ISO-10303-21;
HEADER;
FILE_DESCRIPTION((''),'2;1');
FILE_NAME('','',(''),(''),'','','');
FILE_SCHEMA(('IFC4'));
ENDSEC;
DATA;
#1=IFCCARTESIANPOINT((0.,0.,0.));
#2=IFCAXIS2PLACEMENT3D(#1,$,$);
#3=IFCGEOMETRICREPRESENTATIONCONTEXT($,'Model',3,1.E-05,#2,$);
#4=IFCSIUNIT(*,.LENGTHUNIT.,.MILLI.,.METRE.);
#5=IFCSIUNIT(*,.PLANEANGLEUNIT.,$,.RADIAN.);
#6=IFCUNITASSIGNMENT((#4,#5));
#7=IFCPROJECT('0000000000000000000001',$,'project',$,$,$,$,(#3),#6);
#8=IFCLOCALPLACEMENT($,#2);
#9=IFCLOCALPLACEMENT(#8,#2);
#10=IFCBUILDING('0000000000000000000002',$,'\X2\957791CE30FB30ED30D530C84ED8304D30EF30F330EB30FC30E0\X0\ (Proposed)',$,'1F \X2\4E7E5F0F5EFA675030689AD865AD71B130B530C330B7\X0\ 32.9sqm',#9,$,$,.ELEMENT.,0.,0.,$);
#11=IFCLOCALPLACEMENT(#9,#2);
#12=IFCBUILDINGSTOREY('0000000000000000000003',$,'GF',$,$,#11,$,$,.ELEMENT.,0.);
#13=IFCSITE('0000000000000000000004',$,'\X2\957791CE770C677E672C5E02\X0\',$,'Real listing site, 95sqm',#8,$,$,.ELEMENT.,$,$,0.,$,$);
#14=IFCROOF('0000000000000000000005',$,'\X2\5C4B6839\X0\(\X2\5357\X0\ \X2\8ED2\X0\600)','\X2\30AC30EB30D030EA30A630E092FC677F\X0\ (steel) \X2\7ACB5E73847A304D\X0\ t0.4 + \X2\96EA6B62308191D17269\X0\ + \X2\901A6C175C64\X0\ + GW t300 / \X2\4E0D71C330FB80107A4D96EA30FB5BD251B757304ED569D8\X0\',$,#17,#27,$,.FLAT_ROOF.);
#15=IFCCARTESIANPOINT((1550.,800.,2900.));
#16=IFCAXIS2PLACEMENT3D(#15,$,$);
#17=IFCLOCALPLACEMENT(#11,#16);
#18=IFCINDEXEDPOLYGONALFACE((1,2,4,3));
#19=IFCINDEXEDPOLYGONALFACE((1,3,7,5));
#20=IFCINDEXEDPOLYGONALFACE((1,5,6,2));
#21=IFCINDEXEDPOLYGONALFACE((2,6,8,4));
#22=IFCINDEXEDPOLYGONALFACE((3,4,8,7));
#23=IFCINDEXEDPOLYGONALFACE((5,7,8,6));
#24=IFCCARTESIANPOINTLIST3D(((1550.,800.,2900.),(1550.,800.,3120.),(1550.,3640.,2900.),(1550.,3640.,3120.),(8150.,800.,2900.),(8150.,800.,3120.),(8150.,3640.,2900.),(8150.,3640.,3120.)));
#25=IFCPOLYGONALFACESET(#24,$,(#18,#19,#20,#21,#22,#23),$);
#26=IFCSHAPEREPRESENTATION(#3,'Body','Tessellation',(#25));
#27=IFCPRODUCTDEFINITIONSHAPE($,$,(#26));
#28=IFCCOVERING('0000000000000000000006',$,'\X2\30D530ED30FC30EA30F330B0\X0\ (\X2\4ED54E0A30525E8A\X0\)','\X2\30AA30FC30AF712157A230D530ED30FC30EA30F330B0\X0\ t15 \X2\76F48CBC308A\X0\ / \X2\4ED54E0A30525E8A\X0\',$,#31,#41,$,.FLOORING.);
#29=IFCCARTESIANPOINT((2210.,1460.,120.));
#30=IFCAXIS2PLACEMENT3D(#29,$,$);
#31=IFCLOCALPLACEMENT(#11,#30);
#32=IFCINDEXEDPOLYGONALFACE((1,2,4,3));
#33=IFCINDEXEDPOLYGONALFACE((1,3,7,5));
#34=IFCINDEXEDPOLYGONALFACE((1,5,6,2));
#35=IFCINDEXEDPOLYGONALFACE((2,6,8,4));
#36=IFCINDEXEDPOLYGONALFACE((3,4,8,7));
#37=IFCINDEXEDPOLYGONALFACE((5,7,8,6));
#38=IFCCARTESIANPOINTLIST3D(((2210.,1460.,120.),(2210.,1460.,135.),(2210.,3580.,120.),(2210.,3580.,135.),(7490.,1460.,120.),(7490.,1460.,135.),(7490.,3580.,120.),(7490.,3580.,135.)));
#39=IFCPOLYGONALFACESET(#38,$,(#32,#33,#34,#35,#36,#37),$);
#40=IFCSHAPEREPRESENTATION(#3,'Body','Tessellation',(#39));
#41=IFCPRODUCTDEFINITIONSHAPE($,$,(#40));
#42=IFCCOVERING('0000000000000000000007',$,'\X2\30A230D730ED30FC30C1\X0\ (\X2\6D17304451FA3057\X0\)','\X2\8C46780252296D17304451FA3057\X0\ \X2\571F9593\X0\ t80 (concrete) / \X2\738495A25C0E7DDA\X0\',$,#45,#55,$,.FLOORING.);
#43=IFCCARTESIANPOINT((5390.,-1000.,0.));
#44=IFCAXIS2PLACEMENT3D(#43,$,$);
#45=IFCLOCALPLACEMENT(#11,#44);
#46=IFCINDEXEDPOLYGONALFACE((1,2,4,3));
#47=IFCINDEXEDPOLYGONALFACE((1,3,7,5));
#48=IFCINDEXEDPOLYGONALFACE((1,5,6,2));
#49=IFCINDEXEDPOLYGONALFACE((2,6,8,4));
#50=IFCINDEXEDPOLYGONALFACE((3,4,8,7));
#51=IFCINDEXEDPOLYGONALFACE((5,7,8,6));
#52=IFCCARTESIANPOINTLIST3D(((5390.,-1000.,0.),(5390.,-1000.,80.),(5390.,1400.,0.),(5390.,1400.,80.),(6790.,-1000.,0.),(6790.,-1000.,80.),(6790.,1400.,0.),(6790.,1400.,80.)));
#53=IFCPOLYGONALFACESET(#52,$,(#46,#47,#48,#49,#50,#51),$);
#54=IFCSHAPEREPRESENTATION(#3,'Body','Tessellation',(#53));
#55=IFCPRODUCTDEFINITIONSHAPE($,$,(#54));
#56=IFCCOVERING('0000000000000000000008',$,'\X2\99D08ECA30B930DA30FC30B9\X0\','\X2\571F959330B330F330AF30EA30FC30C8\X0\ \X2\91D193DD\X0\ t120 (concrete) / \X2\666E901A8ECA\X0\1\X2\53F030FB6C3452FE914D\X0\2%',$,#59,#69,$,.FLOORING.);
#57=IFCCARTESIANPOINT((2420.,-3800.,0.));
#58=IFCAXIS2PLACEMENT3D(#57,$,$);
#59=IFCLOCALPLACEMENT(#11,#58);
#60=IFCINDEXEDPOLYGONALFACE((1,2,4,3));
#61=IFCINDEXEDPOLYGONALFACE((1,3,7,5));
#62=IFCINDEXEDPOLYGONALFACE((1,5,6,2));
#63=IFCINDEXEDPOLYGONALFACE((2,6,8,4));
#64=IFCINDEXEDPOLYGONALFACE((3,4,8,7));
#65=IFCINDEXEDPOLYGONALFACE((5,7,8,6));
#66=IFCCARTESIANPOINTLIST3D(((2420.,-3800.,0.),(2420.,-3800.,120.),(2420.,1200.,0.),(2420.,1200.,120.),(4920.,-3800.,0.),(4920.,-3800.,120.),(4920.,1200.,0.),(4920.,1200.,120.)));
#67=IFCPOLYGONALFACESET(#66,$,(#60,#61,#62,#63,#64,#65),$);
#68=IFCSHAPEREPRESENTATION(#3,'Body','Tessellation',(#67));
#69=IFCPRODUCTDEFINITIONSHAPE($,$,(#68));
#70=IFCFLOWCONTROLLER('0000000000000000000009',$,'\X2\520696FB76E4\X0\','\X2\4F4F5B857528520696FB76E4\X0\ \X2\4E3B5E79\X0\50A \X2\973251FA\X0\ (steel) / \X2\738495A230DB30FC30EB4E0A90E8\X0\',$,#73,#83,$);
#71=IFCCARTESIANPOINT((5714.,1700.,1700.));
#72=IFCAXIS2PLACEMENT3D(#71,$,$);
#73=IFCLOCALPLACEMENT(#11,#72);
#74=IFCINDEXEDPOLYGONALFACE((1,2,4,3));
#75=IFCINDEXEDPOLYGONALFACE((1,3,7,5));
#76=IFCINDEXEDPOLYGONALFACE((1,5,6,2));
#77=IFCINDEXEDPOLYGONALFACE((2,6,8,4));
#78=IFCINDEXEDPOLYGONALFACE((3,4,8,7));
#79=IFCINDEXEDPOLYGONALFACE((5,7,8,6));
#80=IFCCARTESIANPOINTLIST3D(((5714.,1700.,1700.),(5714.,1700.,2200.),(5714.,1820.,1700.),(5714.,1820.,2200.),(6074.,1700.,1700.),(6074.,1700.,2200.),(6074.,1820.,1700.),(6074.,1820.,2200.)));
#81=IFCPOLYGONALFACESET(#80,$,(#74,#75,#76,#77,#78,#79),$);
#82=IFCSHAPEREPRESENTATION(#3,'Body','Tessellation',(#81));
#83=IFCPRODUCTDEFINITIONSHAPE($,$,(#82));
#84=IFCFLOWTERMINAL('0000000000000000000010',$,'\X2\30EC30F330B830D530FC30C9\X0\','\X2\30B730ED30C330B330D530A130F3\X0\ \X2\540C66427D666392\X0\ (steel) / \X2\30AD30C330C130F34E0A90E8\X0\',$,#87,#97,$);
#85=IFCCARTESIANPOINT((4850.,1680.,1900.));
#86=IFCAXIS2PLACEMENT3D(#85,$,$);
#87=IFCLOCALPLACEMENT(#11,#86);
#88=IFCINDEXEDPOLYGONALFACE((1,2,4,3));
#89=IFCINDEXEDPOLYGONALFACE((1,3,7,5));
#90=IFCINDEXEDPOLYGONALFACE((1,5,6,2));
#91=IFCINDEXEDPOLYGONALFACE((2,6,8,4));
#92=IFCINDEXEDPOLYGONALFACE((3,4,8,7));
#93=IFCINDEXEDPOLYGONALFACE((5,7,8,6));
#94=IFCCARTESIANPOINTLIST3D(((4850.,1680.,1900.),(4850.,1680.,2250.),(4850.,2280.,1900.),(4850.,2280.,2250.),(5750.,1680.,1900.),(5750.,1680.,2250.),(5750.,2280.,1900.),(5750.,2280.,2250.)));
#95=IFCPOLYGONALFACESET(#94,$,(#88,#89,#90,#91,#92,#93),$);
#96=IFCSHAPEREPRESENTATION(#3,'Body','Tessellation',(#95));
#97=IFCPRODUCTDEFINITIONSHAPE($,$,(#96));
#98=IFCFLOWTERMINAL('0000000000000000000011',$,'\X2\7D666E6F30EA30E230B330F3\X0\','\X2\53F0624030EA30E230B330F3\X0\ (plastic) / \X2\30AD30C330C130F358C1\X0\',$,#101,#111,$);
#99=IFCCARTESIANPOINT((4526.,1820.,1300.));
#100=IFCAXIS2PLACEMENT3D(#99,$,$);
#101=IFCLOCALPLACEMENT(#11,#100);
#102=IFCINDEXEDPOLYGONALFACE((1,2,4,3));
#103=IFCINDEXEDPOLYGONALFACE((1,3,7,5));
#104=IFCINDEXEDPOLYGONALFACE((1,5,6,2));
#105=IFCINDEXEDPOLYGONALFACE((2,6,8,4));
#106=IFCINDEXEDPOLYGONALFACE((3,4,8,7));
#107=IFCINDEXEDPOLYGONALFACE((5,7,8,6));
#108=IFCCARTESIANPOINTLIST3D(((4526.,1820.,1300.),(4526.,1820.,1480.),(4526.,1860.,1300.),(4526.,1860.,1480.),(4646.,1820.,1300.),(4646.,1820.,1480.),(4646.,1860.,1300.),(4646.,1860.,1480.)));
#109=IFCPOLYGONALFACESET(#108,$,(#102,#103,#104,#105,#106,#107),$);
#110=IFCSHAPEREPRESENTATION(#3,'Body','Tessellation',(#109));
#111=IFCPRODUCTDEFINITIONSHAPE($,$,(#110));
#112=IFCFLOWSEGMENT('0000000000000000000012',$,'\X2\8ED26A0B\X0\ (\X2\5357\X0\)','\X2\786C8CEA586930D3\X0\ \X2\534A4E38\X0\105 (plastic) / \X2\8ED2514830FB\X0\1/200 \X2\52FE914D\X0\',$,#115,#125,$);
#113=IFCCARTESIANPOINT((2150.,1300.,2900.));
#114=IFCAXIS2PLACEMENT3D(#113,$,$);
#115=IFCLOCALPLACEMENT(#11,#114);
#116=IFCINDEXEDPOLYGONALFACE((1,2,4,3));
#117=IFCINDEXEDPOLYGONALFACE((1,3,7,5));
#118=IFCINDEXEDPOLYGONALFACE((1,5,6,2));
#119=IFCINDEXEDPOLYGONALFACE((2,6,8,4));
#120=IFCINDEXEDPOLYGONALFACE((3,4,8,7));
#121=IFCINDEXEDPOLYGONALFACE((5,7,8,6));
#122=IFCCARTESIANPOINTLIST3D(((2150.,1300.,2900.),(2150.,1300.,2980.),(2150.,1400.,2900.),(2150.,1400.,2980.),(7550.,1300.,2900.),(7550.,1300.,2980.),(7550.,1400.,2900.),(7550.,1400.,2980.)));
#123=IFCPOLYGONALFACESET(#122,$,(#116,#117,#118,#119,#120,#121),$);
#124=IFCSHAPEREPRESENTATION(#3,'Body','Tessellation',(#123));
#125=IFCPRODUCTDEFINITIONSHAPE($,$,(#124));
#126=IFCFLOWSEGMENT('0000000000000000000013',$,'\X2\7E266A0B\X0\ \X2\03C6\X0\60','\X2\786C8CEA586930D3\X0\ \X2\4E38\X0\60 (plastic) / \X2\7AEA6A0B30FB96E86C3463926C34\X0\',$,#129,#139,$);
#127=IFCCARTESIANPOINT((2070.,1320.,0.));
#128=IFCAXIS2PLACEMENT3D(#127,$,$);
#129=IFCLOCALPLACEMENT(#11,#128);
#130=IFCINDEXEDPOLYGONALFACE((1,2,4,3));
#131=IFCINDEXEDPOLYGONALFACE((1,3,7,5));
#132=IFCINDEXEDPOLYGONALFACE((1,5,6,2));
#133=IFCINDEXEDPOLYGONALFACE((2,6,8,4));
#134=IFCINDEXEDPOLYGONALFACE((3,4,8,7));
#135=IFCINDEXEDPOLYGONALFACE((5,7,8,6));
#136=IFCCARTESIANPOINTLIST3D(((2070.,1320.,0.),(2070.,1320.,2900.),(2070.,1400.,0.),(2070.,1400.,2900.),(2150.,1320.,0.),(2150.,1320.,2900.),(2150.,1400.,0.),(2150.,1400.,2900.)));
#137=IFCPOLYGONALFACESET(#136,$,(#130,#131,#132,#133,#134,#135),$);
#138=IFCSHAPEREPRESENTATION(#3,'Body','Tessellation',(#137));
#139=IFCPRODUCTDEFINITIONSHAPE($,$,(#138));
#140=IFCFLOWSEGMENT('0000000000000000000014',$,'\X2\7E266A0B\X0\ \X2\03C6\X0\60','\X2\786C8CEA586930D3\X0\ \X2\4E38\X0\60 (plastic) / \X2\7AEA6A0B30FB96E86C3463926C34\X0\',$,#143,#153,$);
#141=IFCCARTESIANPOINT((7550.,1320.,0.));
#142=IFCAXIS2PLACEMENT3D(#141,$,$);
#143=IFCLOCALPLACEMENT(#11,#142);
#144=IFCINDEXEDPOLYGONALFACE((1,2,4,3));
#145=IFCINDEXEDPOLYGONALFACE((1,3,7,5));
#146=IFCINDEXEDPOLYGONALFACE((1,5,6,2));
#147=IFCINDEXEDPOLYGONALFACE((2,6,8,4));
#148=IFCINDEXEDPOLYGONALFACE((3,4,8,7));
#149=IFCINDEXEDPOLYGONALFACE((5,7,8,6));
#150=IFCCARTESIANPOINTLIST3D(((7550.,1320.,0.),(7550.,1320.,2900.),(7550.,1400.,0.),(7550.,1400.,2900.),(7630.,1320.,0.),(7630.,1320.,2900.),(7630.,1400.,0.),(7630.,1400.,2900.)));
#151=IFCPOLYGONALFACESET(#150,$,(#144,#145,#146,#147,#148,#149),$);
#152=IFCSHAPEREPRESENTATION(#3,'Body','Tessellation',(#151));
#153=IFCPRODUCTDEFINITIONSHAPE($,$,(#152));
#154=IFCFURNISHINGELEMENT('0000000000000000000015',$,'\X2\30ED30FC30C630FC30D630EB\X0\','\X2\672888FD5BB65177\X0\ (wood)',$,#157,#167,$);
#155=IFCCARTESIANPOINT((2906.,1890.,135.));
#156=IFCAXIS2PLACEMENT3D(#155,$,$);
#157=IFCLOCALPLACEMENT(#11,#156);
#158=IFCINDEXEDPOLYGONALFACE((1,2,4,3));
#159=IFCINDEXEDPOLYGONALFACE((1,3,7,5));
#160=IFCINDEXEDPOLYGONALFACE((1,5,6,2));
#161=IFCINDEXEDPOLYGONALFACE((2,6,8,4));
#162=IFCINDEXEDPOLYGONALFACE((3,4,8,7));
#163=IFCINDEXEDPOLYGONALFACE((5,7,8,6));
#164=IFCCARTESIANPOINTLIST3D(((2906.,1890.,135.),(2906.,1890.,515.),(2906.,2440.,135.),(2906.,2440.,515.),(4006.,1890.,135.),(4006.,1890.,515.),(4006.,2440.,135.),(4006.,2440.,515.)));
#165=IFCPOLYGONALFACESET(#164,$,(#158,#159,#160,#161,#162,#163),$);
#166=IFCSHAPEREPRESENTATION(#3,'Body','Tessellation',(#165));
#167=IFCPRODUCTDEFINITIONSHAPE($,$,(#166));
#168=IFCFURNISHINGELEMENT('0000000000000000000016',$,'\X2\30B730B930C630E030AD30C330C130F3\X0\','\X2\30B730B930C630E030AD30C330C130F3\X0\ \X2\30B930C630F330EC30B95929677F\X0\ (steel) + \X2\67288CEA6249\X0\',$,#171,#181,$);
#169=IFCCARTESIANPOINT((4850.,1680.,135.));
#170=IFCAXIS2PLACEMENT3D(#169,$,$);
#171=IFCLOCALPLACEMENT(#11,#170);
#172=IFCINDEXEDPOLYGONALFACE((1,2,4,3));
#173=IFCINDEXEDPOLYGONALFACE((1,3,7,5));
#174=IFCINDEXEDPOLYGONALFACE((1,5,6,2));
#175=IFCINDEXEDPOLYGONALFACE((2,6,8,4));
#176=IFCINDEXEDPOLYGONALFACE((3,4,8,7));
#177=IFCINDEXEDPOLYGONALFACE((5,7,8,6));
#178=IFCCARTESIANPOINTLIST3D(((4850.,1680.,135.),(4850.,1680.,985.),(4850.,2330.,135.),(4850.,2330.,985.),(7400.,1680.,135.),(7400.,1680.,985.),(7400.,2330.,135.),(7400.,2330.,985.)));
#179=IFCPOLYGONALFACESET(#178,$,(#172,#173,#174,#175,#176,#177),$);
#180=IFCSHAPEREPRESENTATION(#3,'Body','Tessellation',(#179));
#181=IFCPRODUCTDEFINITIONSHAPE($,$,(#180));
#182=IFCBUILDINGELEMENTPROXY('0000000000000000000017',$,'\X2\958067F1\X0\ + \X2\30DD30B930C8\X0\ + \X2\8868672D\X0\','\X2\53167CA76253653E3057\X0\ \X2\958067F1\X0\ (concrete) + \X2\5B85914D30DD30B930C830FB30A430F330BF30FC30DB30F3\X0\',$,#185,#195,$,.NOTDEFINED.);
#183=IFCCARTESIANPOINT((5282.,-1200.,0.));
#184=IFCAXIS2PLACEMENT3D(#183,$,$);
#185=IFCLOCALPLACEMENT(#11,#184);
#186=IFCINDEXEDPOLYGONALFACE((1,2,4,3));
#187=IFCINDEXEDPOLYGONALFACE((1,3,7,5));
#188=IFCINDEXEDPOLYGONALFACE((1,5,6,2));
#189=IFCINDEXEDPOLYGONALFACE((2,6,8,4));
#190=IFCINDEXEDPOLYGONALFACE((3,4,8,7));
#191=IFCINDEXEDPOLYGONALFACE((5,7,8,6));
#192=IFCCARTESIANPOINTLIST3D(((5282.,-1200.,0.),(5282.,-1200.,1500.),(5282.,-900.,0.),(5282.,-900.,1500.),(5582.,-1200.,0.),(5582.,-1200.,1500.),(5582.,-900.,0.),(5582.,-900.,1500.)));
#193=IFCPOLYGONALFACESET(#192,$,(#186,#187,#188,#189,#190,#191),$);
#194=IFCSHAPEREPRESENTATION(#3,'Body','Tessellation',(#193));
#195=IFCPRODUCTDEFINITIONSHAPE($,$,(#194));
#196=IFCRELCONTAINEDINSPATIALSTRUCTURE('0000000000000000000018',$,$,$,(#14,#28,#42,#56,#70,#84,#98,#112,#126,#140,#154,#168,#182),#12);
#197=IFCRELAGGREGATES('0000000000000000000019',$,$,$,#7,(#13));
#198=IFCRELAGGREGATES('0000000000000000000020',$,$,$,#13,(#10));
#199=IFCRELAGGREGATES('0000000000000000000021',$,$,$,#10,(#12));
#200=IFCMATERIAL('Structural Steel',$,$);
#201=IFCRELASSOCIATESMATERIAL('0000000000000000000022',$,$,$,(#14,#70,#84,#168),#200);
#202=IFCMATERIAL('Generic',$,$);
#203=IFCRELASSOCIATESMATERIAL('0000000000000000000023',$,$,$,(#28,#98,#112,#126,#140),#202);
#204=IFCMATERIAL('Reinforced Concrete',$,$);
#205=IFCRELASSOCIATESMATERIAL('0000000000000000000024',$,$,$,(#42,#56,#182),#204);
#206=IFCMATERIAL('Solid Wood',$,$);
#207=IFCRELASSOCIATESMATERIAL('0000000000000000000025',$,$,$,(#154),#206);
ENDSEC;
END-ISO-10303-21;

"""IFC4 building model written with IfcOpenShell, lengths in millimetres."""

from ifc_helpers import new_model, si_unit, frame, frame_2d, origin, place, context, project, spatial, rectangle, extrude, material, element, save


model = new_model("IFC4")

# Units and contexts
model_context = context("Model", 3, precision=1e-05, world=origin())
ifc_project = project(units=[si_unit("LENGTHUNIT", "METRE", prefix="MILLI"), si_unit("PLANEANGLEUNIT", "RADIAN")], contexts=[model_context])

# Site, building, storey
site_placement = place(None, origin())
site = spatial("IfcSite", under=ifc_project, at=site_placement, Name="長野県松本市", ObjectType="Real listing site, 95sqm", CompositionType="ELEMENT", RefElevation=0.0)
building_placement = place(site_placement, origin())
building = spatial("IfcBuilding", under=site, at=building_placement, Name="長野・ロフト付きワンルーム (Proposed)", ObjectType="1F 乾式建材と高断熱サッシ 32.9sqm", CompositionType="ELEMENT", ElevationOfRefHeight=0.0, ElevationOfTerrain=0.0)
storey_placement = place(building_placement, origin())
storey = spatial("IfcBuildingStorey", under=building, at=storey_placement, Name="GF", CompositionType="ELEMENT", Elevation=0.0)

# Shared definitions
ifc_material_1 = material(Name="Solid Wood")

# Shared definitions
ifc_material_2 = material(Name="Reinforced Concrete")

# Roof
ifc_material_3 = material(Name="Structural Steel")
roof_placement = place(storey_placement, frame((1550.0, 800.0, 2900.0)))
element("IfcRoof", 1, at=roof_placement, inside=storey, material=ifc_material_3, Name="屋根(南 軒600)", Description="ガルバリウム鋼板 (steel) 立平葺き t0.4 + 雪止め金物 + 通気層 + GW t300 / 不燃・耐積雪・寒冷地仕様", PredefinedType="FLAT_ROOF", context=model_context, shape_type="SweptSolid", body=[
    extrude(rectangle(XDim=6600.0, YDim=2840.0, at=frame_2d((3300.0, 1420.0))), frame((1550.0, 800.0, 2900.0)), (0.0, 0.0, 1.0), 220.0),
])

# Coverings
ifc_material_4 = material(Name="Generic")
covering_1_placement = place(storey_placement, frame((2210.0, 1460.0, 120.0)))
element("IfcCovering", 2, at=covering_1_placement, inside=storey, material=ifc_material_4, Name="フローリング (仕上げ床)", Description="オーク無垢フローリング t15 直貼り / 仕上げ床", PredefinedType="FLOORING", context=model_context, shape_type="SweptSolid", body=[
    extrude(rectangle(XDim=5280.0, YDim=2120.0, at=frame_2d((2640.0, 1060.0))), frame((2210.0, 1460.0, 120.0)), (0.0, 0.0, 1.0), 15.0),
])
covering_2_placement = place(storey_placement, frame((5390.0, -1000.0, 0.0)))
element("IfcCovering", 3, at=covering_2_placement, inside=storey, material=ifc_material_2, Name="アプローチ (洗い出し)", Description="豆砂利洗い出し 土間 t80 (concrete) / 玄関導線", PredefinedType="FLOORING", context=model_context, shape_type="SweptSolid", body=[
    extrude(rectangle(XDim=1400.0, YDim=2400.0, at=frame_2d((700.0, 1200.0))), frame((5390.0, -1000.0, 0.0)), (0.0, 0.0, 1.0), 80.0),
])
covering_3_placement = place(storey_placement, frame((2420.0, -3800.0, 0.0)))
element("IfcCovering", 4, at=covering_3_placement, inside=storey, material=ifc_material_2, Name="駐車スペース", Description="土間コンクリート 金鏝 t120 (concrete) / 普通車1台・水勾配2%", PredefinedType="FLOORING", context=model_context, shape_type="SweptSolid", body=[
    extrude(rectangle(XDim=2500.0, YDim=5000.0, at=frame_2d((1250.0, 2500.0))), frame((2420.0, -3800.0, 0.0)), (0.0, 0.0, 1.0), 120.0),
])

# Flow controller
flow_controller_placement = place(storey_placement, frame((5714.0, 1700.0, 1700.0)))
element("IfcFlowController", 5, at=flow_controller_placement, inside=storey, material=ifc_material_3, Name="分電盤", Description="住宅用分電盤 主幹50A 露出 (steel) / 玄関ホール上部", context=model_context, shape_type="SweptSolid", body=[
    extrude(rectangle(XDim=360.0, YDim=120.0, at=frame_2d((180.0, 60.0))), frame((5714.0, 1700.0, 1700.0)), (0.0, 0.0, 1.0), 500.0),
])

# Flow terminals
flow_terminal_1_placement = place(storey_placement, frame((4850.0, 1680.0, 1900.0)))
element("IfcFlowTerminal", 6, at=flow_terminal_1_placement, inside=storey, material=ifc_material_3, Name="レンジフード", Description="シロッコファン 同時給排 (steel) / キッチン上部", context=model_context, shape_type="SweptSolid", body=[
    extrude(rectangle(XDim=900.0, YDim=600.0, at=frame_2d((450.0, 300.0))), frame((4850.0, 1680.0, 1900.0)), (0.0, 0.0, 1.0), 350.0),
])
flow_terminal_2_placement = place(storey_placement, frame((4526.0, 1820.0, 1300.0)))
element("IfcFlowTerminal", 7, at=flow_terminal_2_placement, inside=storey, material=ifc_material_4, Name="給湯リモコン", Description="台所リモコン (plastic) / キッチン壁", context=model_context, shape_type="SweptSolid", body=[
    extrude(rectangle(XDim=120.0, YDim=40.0, at=frame_2d((60.0, 20.0))), frame((4526.0, 1820.0, 1300.0)), (0.0, 0.0, 1.0), 180.0),
])

# Flow segments
flow_segment_1_placement = place(storey_placement, frame((2150.0, 1300.0, 2900.0)))
element("IfcFlowSegment", 8, at=flow_segment_1_placement, inside=storey, material=ifc_material_4, Name="軒樋 (南)", Description="硬質塩ビ 半丸105 (plastic) / 軒先・1/200 勾配", context=model_context, shape_type="SweptSolid", body=[
    extrude(rectangle(XDim=5400.0, YDim=100.0, at=frame_2d((2700.0, 50.0))), frame((2150.0, 1300.0, 2900.0)), (0.0, 0.0, 1.0), 80.0),
])
flow_segment_2_placement = place(storey_placement, frame((2070.0, 1320.0, 0.0)))
element("IfcFlowSegment", 9, at=flow_segment_2_placement, inside=storey, material=ifc_material_4, Name="縦樋 φ60", Description="硬質塩ビ 丸60 (plastic) / 竪樋・雨水排水", context=model_context, shape_type="SweptSolid", body=[
    extrude(rectangle(XDim=80.0, YDim=80.0, at=frame_2d((40.0, 40.0))), frame((2070.0, 1320.0, 0.0)), (0.0, 0.0, 1.0), 2900.0),
])
flow_segment_3_placement = place(storey_placement, frame((7550.0, 1320.0, 0.0)))
element("IfcFlowSegment", 10, at=flow_segment_3_placement, inside=storey, material=ifc_material_4, Name="縦樋 φ60", Description="硬質塩ビ 丸60 (plastic) / 竪樋・雨水排水", context=model_context, shape_type="SweptSolid", body=[
    extrude(rectangle(XDim=80.0, YDim=80.0, at=frame_2d((40.0, 40.0))), frame((7550.0, 1320.0, 0.0)), (0.0, 0.0, 1.0), 2900.0),
])

# Furnishing elements
furnishing_1_placement = place(storey_placement, frame((2906.0, 1890.0, 135.0)))
element("IfcFurnishingElement", 11, at=furnishing_1_placement, inside=storey, material=ifc_material_1, Name="ローテーブル", Description="木製家具 (wood)", context=model_context, shape_type="SweptSolid", body=[
    extrude(rectangle(XDim=1100.0, YDim=550.0, at=frame_2d((550.0, 275.0))), frame((2906.0, 1890.0, 135.0)), (0.0, 0.0, 1.0), 380.0),
])
furnishing_2_placement = place(storey_placement, frame((4850.0, 1680.0, 135.0)))
element("IfcFurnishingElement", 12, at=furnishing_2_placement, inside=storey, material=ifc_material_3, Name="システムキッチン", Description="システムキッチン ステンレス天板 (steel) + 木質扉", context=model_context, shape_type="SweptSolid", body=[
    extrude(rectangle(XDim=2550.0, YDim=650.0, at=frame_2d((1275.0, 325.0))), frame((4850.0, 1680.0, 135.0)), (0.0, 0.0, 1.0), 850.0),
])

# Building element proxy
proxy_placement = place(storey_placement, frame((5282.0, -1200.0, 0.0)))
element("IfcBuildingElementProxy", 13, at=proxy_placement, inside=storey, material=ifc_material_2, Name="門柱 + ポスト + 表札", Description="化粧打放し 門柱 (concrete) + 宅配ポスト・インターホン", PredefinedType="NOTDEFINED", context=model_context, shape_type="SweptSolid", body=[
    extrude(rectangle(XDim=300.0, YDim=300.0, at=frame_2d((150.0, 150.0))), frame((5282.0, -1200.0, 0.0)), (0.0, 0.0, 1.0), 1500.0),
])

save(model, "model.ifc")
